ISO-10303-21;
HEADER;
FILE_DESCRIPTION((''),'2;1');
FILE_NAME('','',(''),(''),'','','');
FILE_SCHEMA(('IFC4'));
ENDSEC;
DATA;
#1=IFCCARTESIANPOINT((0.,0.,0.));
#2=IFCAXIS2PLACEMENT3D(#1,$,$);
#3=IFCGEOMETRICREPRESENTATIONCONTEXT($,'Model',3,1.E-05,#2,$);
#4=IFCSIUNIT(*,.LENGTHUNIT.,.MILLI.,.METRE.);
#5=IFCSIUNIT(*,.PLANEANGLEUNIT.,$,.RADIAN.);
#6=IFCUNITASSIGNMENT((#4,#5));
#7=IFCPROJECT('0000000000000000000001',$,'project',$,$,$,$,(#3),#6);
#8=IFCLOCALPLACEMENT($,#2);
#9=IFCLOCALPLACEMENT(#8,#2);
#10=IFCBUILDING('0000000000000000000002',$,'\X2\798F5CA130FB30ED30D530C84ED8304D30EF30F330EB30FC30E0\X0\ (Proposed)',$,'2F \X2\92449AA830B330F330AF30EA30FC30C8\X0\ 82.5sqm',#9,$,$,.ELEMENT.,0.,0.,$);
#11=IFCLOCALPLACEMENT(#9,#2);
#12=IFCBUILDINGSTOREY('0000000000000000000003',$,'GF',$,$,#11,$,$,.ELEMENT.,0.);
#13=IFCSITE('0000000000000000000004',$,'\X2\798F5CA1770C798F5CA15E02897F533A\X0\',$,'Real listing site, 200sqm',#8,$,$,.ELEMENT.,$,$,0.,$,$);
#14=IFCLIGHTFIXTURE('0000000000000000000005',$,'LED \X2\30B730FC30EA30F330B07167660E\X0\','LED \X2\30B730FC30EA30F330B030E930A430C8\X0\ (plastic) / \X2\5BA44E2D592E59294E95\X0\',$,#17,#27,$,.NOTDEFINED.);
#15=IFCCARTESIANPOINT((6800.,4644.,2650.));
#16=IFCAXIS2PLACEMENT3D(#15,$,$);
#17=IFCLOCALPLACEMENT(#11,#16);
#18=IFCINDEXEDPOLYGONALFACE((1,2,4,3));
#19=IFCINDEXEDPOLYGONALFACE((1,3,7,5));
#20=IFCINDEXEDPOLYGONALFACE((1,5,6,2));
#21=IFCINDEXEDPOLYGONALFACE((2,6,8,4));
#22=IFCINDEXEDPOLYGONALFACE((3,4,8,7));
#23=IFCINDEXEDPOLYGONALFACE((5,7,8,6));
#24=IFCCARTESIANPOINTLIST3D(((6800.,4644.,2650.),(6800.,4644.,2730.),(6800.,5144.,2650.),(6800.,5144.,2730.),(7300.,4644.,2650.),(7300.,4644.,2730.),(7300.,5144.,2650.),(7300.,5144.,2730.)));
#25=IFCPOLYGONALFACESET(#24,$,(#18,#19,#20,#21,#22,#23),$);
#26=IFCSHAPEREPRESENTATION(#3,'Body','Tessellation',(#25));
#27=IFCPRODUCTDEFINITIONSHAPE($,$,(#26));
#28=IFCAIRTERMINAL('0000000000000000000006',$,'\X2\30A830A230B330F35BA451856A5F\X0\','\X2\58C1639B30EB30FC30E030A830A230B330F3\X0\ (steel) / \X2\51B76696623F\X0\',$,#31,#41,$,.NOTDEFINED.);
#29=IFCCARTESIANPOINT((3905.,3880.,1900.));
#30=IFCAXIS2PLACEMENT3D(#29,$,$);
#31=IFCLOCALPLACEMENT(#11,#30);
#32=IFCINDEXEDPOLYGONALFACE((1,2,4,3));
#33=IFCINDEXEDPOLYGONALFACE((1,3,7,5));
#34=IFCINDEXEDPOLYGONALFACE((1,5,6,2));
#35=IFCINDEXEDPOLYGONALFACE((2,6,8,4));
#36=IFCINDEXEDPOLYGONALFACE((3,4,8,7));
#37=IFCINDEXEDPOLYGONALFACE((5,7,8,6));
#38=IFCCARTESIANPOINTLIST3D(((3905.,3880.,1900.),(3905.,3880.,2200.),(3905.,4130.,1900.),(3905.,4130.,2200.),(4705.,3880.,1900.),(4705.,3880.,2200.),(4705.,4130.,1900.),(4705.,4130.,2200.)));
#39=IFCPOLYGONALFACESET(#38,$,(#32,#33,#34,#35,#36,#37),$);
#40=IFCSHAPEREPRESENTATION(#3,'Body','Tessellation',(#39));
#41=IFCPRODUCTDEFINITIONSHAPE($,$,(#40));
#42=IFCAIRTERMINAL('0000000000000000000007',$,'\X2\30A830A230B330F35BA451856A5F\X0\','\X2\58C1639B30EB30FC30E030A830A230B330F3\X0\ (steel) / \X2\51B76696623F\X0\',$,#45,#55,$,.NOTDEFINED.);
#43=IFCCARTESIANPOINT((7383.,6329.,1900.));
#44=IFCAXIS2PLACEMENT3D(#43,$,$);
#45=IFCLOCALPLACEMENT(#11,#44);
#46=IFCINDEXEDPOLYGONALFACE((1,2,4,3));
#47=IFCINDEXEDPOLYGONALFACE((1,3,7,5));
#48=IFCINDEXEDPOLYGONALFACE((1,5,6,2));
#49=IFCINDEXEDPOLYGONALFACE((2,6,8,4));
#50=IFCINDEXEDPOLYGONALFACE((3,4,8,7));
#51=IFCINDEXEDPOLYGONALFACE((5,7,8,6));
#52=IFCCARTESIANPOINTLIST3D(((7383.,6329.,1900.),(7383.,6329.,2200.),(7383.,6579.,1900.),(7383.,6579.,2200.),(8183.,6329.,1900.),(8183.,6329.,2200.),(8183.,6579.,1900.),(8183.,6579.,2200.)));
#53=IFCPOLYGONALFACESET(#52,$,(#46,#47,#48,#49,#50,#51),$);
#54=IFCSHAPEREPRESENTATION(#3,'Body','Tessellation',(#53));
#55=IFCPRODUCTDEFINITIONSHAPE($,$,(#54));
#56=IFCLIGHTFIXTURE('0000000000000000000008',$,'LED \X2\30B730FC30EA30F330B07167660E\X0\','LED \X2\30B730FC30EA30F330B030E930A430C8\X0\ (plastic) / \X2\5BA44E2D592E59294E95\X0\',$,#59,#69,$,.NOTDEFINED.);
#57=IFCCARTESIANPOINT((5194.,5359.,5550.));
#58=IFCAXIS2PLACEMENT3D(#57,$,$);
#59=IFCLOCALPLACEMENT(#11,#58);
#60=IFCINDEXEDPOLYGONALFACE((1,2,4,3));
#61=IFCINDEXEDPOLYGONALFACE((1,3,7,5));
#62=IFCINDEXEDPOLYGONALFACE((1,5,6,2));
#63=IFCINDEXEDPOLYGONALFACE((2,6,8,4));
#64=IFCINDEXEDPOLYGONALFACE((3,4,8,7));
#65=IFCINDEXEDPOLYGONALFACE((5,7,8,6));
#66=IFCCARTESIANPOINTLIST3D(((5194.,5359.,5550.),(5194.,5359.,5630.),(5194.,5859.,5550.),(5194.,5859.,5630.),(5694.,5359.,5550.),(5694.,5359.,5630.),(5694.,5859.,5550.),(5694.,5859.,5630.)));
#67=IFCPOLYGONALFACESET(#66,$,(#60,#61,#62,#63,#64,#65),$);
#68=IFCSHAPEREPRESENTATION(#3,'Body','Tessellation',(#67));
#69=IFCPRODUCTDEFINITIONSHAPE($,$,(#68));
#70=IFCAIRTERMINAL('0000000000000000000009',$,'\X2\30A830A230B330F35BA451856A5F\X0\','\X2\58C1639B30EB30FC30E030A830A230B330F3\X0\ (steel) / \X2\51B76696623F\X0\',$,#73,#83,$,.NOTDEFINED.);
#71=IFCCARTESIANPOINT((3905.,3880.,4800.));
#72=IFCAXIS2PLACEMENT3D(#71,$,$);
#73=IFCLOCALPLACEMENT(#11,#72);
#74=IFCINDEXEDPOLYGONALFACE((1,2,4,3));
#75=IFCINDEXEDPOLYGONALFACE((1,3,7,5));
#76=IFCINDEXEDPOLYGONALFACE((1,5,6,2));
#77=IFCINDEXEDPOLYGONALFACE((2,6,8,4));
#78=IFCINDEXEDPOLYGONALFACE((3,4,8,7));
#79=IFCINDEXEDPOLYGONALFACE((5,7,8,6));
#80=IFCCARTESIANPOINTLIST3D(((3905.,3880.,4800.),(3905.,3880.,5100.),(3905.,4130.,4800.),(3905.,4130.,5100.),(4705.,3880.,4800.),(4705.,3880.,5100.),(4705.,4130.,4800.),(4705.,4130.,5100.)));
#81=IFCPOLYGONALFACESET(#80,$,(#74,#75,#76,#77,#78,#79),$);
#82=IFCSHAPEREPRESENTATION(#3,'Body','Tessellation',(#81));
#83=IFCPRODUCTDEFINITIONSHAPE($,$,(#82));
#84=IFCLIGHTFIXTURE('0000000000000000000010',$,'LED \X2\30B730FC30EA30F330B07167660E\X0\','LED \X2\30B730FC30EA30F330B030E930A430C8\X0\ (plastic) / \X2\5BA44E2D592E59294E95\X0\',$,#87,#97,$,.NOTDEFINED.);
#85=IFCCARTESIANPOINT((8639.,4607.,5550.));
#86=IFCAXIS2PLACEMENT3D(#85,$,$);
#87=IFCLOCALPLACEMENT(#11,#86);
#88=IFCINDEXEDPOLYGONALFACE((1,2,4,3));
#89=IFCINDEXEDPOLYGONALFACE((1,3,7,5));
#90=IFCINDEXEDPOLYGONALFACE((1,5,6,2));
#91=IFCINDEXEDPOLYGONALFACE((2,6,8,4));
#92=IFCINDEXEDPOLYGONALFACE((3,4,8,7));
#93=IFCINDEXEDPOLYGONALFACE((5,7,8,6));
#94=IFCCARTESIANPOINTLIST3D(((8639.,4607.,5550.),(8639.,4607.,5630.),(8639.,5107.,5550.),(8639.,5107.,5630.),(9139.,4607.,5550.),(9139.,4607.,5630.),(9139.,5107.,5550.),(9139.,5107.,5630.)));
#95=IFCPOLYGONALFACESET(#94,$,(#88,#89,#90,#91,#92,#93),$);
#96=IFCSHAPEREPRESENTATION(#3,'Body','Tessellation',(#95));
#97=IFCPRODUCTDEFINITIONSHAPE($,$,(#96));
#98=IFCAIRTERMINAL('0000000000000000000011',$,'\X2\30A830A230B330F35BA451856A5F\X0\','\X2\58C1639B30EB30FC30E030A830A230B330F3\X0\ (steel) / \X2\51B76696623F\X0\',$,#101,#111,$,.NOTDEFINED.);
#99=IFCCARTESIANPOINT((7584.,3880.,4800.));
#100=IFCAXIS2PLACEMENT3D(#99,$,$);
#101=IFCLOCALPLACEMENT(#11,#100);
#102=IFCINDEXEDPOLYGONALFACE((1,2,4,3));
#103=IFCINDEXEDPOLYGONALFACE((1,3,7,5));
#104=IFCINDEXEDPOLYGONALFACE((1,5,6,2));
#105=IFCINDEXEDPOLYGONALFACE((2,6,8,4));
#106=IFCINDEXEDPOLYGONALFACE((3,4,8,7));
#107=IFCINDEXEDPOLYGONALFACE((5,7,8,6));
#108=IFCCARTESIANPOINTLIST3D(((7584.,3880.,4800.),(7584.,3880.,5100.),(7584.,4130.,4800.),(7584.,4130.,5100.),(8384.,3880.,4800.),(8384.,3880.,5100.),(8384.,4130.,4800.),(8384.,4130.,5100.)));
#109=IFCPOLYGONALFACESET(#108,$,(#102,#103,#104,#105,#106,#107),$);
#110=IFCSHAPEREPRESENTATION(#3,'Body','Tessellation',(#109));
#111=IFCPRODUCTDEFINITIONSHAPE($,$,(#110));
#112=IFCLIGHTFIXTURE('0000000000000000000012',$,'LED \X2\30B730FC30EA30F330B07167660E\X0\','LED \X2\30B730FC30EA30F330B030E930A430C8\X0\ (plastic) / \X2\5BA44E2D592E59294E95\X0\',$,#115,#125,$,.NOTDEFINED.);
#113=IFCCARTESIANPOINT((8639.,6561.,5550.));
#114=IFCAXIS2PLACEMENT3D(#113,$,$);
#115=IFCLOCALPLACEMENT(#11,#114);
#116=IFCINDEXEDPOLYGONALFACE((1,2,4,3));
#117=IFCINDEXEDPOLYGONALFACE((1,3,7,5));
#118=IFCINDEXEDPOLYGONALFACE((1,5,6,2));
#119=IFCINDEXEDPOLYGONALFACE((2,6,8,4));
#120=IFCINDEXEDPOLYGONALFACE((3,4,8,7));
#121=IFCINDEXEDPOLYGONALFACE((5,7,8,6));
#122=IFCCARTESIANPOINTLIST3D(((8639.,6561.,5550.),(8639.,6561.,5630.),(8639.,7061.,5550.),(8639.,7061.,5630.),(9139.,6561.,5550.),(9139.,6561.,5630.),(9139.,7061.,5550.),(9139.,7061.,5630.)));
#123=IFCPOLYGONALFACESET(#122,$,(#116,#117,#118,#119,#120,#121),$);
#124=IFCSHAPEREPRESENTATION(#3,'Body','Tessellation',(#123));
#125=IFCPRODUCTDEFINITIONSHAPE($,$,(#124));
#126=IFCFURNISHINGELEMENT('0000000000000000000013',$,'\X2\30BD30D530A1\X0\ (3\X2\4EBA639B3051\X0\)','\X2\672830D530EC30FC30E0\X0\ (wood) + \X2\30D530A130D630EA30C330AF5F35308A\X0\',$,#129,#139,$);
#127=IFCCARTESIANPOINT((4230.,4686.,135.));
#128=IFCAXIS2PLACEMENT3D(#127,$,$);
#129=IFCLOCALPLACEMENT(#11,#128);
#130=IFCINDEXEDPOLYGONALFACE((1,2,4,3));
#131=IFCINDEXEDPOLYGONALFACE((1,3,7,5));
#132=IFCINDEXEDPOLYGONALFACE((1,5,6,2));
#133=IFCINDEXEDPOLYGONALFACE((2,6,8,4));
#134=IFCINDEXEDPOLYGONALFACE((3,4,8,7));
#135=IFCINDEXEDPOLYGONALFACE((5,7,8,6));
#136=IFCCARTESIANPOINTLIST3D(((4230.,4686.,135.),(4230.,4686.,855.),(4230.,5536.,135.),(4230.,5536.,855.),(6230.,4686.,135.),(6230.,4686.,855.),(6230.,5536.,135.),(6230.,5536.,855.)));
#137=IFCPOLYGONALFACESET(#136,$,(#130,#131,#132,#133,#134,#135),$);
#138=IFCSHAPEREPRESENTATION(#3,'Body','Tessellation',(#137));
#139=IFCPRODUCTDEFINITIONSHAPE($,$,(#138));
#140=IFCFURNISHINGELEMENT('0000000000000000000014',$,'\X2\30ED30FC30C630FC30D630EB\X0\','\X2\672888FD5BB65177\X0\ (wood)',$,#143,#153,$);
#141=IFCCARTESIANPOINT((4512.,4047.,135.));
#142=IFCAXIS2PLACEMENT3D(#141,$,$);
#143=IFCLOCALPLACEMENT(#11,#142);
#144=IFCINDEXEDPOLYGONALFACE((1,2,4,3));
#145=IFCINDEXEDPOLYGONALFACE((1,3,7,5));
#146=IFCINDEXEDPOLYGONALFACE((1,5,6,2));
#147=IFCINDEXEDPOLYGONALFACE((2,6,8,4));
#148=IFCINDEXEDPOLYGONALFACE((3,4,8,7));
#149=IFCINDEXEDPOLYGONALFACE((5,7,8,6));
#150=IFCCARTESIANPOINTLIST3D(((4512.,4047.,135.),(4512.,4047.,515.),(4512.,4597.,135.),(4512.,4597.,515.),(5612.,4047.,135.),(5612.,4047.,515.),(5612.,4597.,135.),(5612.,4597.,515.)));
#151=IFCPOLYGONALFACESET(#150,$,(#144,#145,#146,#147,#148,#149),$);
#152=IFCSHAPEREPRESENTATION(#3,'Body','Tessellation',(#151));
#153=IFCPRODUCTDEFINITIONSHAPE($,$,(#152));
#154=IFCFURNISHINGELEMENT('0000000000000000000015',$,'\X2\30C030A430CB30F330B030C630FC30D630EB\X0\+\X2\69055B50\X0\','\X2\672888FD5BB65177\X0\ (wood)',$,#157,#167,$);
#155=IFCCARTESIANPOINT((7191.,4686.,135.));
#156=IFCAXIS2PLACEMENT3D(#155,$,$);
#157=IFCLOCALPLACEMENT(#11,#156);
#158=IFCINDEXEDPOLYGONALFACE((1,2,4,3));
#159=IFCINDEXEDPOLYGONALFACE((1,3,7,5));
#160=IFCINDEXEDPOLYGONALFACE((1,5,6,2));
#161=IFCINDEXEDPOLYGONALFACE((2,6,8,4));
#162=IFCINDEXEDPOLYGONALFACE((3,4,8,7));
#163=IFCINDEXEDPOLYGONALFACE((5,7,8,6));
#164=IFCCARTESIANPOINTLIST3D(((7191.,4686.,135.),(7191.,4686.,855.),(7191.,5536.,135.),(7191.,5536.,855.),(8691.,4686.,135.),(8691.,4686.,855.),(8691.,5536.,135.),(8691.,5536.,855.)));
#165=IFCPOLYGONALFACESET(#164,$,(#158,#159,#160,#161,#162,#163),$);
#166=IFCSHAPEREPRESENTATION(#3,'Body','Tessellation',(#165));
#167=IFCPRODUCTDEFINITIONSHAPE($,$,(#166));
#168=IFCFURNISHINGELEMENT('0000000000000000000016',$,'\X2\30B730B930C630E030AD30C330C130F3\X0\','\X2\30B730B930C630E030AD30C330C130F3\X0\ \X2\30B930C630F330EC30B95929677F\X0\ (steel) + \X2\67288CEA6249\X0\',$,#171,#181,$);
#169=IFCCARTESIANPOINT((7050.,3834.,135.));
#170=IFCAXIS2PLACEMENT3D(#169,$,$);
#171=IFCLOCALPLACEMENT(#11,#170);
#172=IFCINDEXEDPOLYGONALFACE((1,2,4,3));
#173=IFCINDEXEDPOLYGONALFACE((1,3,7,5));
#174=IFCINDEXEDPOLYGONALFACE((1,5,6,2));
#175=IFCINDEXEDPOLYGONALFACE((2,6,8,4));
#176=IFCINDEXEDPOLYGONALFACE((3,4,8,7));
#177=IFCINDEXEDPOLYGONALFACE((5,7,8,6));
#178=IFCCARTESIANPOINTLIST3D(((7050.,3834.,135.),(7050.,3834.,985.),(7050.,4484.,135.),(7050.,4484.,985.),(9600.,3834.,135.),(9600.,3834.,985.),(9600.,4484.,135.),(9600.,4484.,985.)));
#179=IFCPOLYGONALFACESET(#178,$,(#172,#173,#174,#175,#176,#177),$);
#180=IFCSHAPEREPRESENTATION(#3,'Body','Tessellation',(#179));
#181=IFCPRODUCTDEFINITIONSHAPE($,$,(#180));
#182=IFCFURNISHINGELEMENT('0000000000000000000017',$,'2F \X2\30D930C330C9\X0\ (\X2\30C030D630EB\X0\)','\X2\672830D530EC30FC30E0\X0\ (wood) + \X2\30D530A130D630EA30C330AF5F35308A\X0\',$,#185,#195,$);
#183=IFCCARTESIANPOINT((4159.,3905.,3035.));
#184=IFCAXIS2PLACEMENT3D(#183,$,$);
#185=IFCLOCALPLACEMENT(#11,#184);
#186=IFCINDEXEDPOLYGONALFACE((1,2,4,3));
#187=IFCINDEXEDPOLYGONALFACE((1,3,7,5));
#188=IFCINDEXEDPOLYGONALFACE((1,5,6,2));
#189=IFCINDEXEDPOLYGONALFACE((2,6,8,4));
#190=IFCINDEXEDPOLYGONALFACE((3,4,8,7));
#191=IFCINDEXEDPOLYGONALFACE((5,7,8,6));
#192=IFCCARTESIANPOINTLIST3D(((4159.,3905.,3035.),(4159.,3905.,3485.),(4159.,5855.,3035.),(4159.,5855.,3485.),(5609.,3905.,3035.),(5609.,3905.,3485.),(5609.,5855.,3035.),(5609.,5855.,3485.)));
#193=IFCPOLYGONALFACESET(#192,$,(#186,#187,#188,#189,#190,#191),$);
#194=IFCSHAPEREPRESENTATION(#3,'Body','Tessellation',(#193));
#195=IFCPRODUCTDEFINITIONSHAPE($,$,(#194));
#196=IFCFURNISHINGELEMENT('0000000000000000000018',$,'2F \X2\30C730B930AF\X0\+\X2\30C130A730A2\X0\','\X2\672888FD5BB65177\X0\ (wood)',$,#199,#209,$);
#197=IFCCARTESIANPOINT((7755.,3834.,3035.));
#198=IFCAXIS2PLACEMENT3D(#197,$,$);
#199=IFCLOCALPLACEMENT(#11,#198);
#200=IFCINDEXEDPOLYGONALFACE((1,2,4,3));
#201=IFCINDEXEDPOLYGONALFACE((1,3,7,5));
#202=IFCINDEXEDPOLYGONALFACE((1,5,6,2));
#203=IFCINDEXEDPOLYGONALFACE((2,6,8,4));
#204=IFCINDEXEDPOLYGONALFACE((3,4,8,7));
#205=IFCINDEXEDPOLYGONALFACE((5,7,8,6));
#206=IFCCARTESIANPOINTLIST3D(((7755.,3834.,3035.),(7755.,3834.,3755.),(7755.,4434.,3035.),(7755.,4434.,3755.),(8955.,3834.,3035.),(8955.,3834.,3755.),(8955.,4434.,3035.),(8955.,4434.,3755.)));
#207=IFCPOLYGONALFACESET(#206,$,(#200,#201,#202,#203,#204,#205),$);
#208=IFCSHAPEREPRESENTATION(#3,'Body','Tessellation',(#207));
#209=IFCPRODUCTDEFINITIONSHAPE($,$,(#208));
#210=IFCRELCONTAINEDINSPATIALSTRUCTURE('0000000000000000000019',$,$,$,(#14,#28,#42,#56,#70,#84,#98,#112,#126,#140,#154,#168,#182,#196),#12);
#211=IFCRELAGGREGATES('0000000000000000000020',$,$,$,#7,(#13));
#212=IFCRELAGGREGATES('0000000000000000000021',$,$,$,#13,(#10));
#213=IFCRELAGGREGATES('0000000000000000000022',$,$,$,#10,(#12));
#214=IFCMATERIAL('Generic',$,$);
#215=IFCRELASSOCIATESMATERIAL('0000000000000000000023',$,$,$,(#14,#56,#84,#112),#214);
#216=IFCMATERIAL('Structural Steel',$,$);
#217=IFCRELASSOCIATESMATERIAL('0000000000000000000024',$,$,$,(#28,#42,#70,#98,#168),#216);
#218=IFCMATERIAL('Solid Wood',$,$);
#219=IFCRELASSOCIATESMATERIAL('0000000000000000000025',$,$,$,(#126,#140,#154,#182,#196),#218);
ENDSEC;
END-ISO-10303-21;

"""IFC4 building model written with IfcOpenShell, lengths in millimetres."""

from ifc_helpers import new_model, si_unit, frame, frame_2d, origin, place, context, project, spatial, rectangle, extrude, material, element, save


model = new_model("IFC4")

# Units and contexts
model_context = context("Model", 3, precision=1e-05, world=origin())
ifc_project = project(units=[si_unit("LENGTHUNIT", "METRE", prefix="MILLI"), si_unit("PLANEANGLEUNIT", "RADIAN")], contexts=[model_context])

# Site, building, storey
site_placement = place(None, origin())
site = spatial("IfcSite", under=ifc_project, at=site_placement, Name="福岡県福岡市西区", ObjectType="Real listing site, 200sqm", CompositionType="ELEMENT", RefElevation=0.0)
building_placement = place(site_placement, origin())
building = spatial("IfcBuilding", under=site, at=building_placement, Name="福岡・ロフト付きワンルーム (Proposed)", ObjectType="2F 鉄骨コンクリート 82.5sqm", CompositionType="ELEMENT", ElevationOfRefHeight=0.0, ElevationOfTerrain=0.0)
storey_placement = place(building_placement, origin())
storey = spatial("IfcBuildingStorey", under=building, at=storey_placement, Name="GF", CompositionType="ELEMENT", Elevation=0.0)

# Shared definitions
ifc_material_1 = material(Name="Solid Wood")

# Shared definitions
ifc_material_2 = material(Name="Structural Steel")

# Shared definitions
ifc_material_3 = material(Name="Generic")

# Light fixture
light_fixture_1_placement = place(storey_placement, frame((6800.0, 4644.0, 2650.0)))
element("IfcLightFixture", 1, at=light_fixture_1_placement, inside=storey, material=ifc_material_3, Name="LED シーリング照明", Description="LED シーリングライト (plastic) / 室中央天井", PredefinedType="NOTDEFINED", context=model_context, shape_type="SweptSolid", body=[
    extrude(rectangle(XDim=500.0, YDim=500.0, at=frame_2d((250.0, 250.0))), frame((6800.0, 4644.0, 2650.0)), (0.0, 0.0, 1.0), 80.0),
])

# Air terminals
air_terminal_1_placement = place(storey_placement, frame((3905.0, 3880.0, 1900.0)))
element("IfcAirTerminal", 2, at=air_terminal_1_placement, inside=storey, material=ifc_material_2, Name="エアコン室内機", Description="壁掛ルームエアコン (steel) / 冷暖房", PredefinedType="NOTDEFINED", context=model_context, shape_type="SweptSolid", body=[
    extrude(rectangle(XDim=800.0, YDim=250.0, at=frame_2d((400.0, 125.0))), frame((3905.0, 3880.0, 1900.0)), (0.0, 0.0, 1.0), 300.0),
])
air_terminal_2_placement = place(storey_placement, frame((7383.0, 6329.0, 1900.0)))
element("IfcAirTerminal", 3, at=air_terminal_2_placement, inside=storey, material=ifc_material_2, Name="エアコン室内機", Description="壁掛ルームエアコン (steel) / 冷暖房", PredefinedType="NOTDEFINED", context=model_context, shape_type="SweptSolid", body=[
    extrude(rectangle(XDim=800.0, YDim=250.0, at=frame_2d((400.0, 125.0))), frame((7383.0, 6329.0, 1900.0)), (0.0, 0.0, 1.0), 300.0),
])

# Light fixture
light_fixture_2_placement = place(storey_placement, frame((5194.0, 5359.0, 5550.0)))
element("IfcLightFixture", 4, at=light_fixture_2_placement, inside=storey, material=ifc_material_3, Name="LED シーリング照明", Description="LED シーリングライト (plastic) / 室中央天井", PredefinedType="NOTDEFINED", context=model_context, shape_type="SweptSolid", body=[
    extrude(rectangle(XDim=500.0, YDim=500.0, at=frame_2d((250.0, 250.0))), frame((5194.0, 5359.0, 5550.0)), (0.0, 0.0, 1.0), 80.0),
])

# Air terminal
air_terminal_3_placement = place(storey_placement, frame((3905.0, 3880.0, 4800.0)))
element("IfcAirTerminal", 5, at=air_terminal_3_placement, inside=storey, material=ifc_material_2, Name="エアコン室内機", Description="壁掛ルームエアコン (steel) / 冷暖房", PredefinedType="NOTDEFINED", context=model_context, shape_type="SweptSolid", body=[
    extrude(rectangle(XDim=800.0, YDim=250.0, at=frame_2d((400.0, 125.0))), frame((3905.0, 3880.0, 4800.0)), (0.0, 0.0, 1.0), 300.0),
])

# Light fixture
light_fixture_3_placement = place(storey_placement, frame((8639.0, 4607.0, 5550.0)))
element("IfcLightFixture", 6, at=light_fixture_3_placement, inside=storey, material=ifc_material_3, Name="LED シーリング照明", Description="LED シーリングライト (plastic) / 室中央天井", PredefinedType="NOTDEFINED", context=model_context, shape_type="SweptSolid", body=[
    extrude(rectangle(XDim=500.0, YDim=500.0, at=frame_2d((250.0, 250.0))), frame((8639.0, 4607.0, 5550.0)), (0.0, 0.0, 1.0), 80.0),
])

# Air terminal
air_terminal_4_placement = place(storey_placement, frame((7584.0, 3880.0, 4800.0)))
element("IfcAirTerminal", 7, at=air_terminal_4_placement, inside=storey, material=ifc_material_2, Name="エアコン室内機", Description="壁掛ルームエアコン (steel) / 冷暖房", PredefinedType="NOTDEFINED", context=model_context, shape_type="SweptSolid", body=[
    extrude(rectangle(XDim=800.0, YDim=250.0, at=frame_2d((400.0, 125.0))), frame((7584.0, 3880.0, 4800.0)), (0.0, 0.0, 1.0), 300.0),
])

# Light fixture
light_fixture_4_placement = place(storey_placement, frame((8639.0, 6561.0, 5550.0)))
element("IfcLightFixture", 8, at=light_fixture_4_placement, inside=storey, material=ifc_material_3, Name="LED シーリング照明", Description="LED シーリングライト (plastic) / 室中央天井", PredefinedType="NOTDEFINED", context=model_context, shape_type="SweptSolid", body=[
    extrude(rectangle(XDim=500.0, YDim=500.0, at=frame_2d((250.0, 250.0))), frame((8639.0, 6561.0, 5550.0)), (0.0, 0.0, 1.0), 80.0),
])

# Furnishing elements
furnishing_1_placement = place(storey_placement, frame((4230.0, 4686.0, 135.0)))
element("IfcFurnishingElement", 9, at=furnishing_1_placement, inside=storey, material=ifc_material_1, Name="ソファ (3人掛け)", Description="木フレーム (wood) + ファブリック張り", context=model_context, shape_type="SweptSolid", body=[
    extrude(rectangle(XDim=2000.0, YDim=850.0, at=frame_2d((1000.0, 425.0))), frame((4230.0, 4686.0, 135.0)), (0.0, 0.0, 1.0), 720.0),
])
furnishing_2_placement = place(storey_placement, frame((4512.0, 4047.0, 135.0)))
element("IfcFurnishingElement", 10, at=furnishing_2_placement, inside=storey, material=ifc_material_1, Name="ローテーブル", Description="木製家具 (wood)", context=model_context, shape_type="SweptSolid", body=[
    extrude(rectangle(XDim=1100.0, YDim=550.0, at=frame_2d((550.0, 275.0))), frame((4512.0, 4047.0, 135.0)), (0.0, 0.0, 1.0), 380.0),
])
furnishing_3_placement = place(storey_placement, frame((7191.0, 4686.0, 135.0)))
element("IfcFurnishingElement", 11, at=furnishing_3_placement, inside=storey, material=ifc_material_1, Name="ダイニングテーブル+椅子", Description="木製家具 (wood)", context=model_context, shape_type="SweptSolid", body=[
    extrude(rectangle(XDim=1500.0, YDim=850.0, at=frame_2d((750.0, 425.0))), frame((7191.0, 4686.0, 135.0)), (0.0, 0.0, 1.0), 720.0),
])
furnishing_4_placement = place(storey_placement, frame((7050.0, 3834.0, 135.0)))
element("IfcFurnishingElement", 12, at=furnishing_4_placement, inside=storey, material=ifc_material_2, Name="システムキッチン", Description="システムキッチン ステンレス天板 (steel) + 木質扉", context=model_context, shape_type="SweptSolid", body=[
    extrude(rectangle(XDim=2550.0, YDim=650.0, at=frame_2d((1275.0, 325.0))), frame((7050.0, 3834.0, 135.0)), (0.0, 0.0, 1.0), 850.0),
])
furnishing_5_placement = place(storey_placement, frame((4159.0, 3905.0, 3035.0)))
element("IfcFurnishingElement", 13, at=furnishing_5_placement, inside=storey, material=ifc_material_1, Name="2F ベッド (ダブル)", Description="木フレーム (wood) + ファブリック張り", context=model_context, shape_type="SweptSolid", body=[
    extrude(rectangle(XDim=1450.0, YDim=1950.0, at=frame_2d((725.0, 975.0))), frame((4159.0, 3905.0, 3035.0)), (0.0, 0.0, 1.0), 450.0),
])
furnishing_6_placement = place(storey_placement, frame((7755.0, 3834.0, 3035.0)))
element("IfcFurnishingElement", 14, at=furnishing_6_placement, inside=storey, material=ifc_material_1, Name="2F デスク+チェア", Description="木製家具 (wood)", context=model_context, shape_type="SweptSolid", body=[
    extrude(rectangle(XDim=1200.0, YDim=600.0, at=frame_2d((600.0, 300.0))), frame((7755.0, 3834.0, 3035.0)), (0.0, 0.0, 1.0), 720.0),
])

save(model, "model.ifc")
